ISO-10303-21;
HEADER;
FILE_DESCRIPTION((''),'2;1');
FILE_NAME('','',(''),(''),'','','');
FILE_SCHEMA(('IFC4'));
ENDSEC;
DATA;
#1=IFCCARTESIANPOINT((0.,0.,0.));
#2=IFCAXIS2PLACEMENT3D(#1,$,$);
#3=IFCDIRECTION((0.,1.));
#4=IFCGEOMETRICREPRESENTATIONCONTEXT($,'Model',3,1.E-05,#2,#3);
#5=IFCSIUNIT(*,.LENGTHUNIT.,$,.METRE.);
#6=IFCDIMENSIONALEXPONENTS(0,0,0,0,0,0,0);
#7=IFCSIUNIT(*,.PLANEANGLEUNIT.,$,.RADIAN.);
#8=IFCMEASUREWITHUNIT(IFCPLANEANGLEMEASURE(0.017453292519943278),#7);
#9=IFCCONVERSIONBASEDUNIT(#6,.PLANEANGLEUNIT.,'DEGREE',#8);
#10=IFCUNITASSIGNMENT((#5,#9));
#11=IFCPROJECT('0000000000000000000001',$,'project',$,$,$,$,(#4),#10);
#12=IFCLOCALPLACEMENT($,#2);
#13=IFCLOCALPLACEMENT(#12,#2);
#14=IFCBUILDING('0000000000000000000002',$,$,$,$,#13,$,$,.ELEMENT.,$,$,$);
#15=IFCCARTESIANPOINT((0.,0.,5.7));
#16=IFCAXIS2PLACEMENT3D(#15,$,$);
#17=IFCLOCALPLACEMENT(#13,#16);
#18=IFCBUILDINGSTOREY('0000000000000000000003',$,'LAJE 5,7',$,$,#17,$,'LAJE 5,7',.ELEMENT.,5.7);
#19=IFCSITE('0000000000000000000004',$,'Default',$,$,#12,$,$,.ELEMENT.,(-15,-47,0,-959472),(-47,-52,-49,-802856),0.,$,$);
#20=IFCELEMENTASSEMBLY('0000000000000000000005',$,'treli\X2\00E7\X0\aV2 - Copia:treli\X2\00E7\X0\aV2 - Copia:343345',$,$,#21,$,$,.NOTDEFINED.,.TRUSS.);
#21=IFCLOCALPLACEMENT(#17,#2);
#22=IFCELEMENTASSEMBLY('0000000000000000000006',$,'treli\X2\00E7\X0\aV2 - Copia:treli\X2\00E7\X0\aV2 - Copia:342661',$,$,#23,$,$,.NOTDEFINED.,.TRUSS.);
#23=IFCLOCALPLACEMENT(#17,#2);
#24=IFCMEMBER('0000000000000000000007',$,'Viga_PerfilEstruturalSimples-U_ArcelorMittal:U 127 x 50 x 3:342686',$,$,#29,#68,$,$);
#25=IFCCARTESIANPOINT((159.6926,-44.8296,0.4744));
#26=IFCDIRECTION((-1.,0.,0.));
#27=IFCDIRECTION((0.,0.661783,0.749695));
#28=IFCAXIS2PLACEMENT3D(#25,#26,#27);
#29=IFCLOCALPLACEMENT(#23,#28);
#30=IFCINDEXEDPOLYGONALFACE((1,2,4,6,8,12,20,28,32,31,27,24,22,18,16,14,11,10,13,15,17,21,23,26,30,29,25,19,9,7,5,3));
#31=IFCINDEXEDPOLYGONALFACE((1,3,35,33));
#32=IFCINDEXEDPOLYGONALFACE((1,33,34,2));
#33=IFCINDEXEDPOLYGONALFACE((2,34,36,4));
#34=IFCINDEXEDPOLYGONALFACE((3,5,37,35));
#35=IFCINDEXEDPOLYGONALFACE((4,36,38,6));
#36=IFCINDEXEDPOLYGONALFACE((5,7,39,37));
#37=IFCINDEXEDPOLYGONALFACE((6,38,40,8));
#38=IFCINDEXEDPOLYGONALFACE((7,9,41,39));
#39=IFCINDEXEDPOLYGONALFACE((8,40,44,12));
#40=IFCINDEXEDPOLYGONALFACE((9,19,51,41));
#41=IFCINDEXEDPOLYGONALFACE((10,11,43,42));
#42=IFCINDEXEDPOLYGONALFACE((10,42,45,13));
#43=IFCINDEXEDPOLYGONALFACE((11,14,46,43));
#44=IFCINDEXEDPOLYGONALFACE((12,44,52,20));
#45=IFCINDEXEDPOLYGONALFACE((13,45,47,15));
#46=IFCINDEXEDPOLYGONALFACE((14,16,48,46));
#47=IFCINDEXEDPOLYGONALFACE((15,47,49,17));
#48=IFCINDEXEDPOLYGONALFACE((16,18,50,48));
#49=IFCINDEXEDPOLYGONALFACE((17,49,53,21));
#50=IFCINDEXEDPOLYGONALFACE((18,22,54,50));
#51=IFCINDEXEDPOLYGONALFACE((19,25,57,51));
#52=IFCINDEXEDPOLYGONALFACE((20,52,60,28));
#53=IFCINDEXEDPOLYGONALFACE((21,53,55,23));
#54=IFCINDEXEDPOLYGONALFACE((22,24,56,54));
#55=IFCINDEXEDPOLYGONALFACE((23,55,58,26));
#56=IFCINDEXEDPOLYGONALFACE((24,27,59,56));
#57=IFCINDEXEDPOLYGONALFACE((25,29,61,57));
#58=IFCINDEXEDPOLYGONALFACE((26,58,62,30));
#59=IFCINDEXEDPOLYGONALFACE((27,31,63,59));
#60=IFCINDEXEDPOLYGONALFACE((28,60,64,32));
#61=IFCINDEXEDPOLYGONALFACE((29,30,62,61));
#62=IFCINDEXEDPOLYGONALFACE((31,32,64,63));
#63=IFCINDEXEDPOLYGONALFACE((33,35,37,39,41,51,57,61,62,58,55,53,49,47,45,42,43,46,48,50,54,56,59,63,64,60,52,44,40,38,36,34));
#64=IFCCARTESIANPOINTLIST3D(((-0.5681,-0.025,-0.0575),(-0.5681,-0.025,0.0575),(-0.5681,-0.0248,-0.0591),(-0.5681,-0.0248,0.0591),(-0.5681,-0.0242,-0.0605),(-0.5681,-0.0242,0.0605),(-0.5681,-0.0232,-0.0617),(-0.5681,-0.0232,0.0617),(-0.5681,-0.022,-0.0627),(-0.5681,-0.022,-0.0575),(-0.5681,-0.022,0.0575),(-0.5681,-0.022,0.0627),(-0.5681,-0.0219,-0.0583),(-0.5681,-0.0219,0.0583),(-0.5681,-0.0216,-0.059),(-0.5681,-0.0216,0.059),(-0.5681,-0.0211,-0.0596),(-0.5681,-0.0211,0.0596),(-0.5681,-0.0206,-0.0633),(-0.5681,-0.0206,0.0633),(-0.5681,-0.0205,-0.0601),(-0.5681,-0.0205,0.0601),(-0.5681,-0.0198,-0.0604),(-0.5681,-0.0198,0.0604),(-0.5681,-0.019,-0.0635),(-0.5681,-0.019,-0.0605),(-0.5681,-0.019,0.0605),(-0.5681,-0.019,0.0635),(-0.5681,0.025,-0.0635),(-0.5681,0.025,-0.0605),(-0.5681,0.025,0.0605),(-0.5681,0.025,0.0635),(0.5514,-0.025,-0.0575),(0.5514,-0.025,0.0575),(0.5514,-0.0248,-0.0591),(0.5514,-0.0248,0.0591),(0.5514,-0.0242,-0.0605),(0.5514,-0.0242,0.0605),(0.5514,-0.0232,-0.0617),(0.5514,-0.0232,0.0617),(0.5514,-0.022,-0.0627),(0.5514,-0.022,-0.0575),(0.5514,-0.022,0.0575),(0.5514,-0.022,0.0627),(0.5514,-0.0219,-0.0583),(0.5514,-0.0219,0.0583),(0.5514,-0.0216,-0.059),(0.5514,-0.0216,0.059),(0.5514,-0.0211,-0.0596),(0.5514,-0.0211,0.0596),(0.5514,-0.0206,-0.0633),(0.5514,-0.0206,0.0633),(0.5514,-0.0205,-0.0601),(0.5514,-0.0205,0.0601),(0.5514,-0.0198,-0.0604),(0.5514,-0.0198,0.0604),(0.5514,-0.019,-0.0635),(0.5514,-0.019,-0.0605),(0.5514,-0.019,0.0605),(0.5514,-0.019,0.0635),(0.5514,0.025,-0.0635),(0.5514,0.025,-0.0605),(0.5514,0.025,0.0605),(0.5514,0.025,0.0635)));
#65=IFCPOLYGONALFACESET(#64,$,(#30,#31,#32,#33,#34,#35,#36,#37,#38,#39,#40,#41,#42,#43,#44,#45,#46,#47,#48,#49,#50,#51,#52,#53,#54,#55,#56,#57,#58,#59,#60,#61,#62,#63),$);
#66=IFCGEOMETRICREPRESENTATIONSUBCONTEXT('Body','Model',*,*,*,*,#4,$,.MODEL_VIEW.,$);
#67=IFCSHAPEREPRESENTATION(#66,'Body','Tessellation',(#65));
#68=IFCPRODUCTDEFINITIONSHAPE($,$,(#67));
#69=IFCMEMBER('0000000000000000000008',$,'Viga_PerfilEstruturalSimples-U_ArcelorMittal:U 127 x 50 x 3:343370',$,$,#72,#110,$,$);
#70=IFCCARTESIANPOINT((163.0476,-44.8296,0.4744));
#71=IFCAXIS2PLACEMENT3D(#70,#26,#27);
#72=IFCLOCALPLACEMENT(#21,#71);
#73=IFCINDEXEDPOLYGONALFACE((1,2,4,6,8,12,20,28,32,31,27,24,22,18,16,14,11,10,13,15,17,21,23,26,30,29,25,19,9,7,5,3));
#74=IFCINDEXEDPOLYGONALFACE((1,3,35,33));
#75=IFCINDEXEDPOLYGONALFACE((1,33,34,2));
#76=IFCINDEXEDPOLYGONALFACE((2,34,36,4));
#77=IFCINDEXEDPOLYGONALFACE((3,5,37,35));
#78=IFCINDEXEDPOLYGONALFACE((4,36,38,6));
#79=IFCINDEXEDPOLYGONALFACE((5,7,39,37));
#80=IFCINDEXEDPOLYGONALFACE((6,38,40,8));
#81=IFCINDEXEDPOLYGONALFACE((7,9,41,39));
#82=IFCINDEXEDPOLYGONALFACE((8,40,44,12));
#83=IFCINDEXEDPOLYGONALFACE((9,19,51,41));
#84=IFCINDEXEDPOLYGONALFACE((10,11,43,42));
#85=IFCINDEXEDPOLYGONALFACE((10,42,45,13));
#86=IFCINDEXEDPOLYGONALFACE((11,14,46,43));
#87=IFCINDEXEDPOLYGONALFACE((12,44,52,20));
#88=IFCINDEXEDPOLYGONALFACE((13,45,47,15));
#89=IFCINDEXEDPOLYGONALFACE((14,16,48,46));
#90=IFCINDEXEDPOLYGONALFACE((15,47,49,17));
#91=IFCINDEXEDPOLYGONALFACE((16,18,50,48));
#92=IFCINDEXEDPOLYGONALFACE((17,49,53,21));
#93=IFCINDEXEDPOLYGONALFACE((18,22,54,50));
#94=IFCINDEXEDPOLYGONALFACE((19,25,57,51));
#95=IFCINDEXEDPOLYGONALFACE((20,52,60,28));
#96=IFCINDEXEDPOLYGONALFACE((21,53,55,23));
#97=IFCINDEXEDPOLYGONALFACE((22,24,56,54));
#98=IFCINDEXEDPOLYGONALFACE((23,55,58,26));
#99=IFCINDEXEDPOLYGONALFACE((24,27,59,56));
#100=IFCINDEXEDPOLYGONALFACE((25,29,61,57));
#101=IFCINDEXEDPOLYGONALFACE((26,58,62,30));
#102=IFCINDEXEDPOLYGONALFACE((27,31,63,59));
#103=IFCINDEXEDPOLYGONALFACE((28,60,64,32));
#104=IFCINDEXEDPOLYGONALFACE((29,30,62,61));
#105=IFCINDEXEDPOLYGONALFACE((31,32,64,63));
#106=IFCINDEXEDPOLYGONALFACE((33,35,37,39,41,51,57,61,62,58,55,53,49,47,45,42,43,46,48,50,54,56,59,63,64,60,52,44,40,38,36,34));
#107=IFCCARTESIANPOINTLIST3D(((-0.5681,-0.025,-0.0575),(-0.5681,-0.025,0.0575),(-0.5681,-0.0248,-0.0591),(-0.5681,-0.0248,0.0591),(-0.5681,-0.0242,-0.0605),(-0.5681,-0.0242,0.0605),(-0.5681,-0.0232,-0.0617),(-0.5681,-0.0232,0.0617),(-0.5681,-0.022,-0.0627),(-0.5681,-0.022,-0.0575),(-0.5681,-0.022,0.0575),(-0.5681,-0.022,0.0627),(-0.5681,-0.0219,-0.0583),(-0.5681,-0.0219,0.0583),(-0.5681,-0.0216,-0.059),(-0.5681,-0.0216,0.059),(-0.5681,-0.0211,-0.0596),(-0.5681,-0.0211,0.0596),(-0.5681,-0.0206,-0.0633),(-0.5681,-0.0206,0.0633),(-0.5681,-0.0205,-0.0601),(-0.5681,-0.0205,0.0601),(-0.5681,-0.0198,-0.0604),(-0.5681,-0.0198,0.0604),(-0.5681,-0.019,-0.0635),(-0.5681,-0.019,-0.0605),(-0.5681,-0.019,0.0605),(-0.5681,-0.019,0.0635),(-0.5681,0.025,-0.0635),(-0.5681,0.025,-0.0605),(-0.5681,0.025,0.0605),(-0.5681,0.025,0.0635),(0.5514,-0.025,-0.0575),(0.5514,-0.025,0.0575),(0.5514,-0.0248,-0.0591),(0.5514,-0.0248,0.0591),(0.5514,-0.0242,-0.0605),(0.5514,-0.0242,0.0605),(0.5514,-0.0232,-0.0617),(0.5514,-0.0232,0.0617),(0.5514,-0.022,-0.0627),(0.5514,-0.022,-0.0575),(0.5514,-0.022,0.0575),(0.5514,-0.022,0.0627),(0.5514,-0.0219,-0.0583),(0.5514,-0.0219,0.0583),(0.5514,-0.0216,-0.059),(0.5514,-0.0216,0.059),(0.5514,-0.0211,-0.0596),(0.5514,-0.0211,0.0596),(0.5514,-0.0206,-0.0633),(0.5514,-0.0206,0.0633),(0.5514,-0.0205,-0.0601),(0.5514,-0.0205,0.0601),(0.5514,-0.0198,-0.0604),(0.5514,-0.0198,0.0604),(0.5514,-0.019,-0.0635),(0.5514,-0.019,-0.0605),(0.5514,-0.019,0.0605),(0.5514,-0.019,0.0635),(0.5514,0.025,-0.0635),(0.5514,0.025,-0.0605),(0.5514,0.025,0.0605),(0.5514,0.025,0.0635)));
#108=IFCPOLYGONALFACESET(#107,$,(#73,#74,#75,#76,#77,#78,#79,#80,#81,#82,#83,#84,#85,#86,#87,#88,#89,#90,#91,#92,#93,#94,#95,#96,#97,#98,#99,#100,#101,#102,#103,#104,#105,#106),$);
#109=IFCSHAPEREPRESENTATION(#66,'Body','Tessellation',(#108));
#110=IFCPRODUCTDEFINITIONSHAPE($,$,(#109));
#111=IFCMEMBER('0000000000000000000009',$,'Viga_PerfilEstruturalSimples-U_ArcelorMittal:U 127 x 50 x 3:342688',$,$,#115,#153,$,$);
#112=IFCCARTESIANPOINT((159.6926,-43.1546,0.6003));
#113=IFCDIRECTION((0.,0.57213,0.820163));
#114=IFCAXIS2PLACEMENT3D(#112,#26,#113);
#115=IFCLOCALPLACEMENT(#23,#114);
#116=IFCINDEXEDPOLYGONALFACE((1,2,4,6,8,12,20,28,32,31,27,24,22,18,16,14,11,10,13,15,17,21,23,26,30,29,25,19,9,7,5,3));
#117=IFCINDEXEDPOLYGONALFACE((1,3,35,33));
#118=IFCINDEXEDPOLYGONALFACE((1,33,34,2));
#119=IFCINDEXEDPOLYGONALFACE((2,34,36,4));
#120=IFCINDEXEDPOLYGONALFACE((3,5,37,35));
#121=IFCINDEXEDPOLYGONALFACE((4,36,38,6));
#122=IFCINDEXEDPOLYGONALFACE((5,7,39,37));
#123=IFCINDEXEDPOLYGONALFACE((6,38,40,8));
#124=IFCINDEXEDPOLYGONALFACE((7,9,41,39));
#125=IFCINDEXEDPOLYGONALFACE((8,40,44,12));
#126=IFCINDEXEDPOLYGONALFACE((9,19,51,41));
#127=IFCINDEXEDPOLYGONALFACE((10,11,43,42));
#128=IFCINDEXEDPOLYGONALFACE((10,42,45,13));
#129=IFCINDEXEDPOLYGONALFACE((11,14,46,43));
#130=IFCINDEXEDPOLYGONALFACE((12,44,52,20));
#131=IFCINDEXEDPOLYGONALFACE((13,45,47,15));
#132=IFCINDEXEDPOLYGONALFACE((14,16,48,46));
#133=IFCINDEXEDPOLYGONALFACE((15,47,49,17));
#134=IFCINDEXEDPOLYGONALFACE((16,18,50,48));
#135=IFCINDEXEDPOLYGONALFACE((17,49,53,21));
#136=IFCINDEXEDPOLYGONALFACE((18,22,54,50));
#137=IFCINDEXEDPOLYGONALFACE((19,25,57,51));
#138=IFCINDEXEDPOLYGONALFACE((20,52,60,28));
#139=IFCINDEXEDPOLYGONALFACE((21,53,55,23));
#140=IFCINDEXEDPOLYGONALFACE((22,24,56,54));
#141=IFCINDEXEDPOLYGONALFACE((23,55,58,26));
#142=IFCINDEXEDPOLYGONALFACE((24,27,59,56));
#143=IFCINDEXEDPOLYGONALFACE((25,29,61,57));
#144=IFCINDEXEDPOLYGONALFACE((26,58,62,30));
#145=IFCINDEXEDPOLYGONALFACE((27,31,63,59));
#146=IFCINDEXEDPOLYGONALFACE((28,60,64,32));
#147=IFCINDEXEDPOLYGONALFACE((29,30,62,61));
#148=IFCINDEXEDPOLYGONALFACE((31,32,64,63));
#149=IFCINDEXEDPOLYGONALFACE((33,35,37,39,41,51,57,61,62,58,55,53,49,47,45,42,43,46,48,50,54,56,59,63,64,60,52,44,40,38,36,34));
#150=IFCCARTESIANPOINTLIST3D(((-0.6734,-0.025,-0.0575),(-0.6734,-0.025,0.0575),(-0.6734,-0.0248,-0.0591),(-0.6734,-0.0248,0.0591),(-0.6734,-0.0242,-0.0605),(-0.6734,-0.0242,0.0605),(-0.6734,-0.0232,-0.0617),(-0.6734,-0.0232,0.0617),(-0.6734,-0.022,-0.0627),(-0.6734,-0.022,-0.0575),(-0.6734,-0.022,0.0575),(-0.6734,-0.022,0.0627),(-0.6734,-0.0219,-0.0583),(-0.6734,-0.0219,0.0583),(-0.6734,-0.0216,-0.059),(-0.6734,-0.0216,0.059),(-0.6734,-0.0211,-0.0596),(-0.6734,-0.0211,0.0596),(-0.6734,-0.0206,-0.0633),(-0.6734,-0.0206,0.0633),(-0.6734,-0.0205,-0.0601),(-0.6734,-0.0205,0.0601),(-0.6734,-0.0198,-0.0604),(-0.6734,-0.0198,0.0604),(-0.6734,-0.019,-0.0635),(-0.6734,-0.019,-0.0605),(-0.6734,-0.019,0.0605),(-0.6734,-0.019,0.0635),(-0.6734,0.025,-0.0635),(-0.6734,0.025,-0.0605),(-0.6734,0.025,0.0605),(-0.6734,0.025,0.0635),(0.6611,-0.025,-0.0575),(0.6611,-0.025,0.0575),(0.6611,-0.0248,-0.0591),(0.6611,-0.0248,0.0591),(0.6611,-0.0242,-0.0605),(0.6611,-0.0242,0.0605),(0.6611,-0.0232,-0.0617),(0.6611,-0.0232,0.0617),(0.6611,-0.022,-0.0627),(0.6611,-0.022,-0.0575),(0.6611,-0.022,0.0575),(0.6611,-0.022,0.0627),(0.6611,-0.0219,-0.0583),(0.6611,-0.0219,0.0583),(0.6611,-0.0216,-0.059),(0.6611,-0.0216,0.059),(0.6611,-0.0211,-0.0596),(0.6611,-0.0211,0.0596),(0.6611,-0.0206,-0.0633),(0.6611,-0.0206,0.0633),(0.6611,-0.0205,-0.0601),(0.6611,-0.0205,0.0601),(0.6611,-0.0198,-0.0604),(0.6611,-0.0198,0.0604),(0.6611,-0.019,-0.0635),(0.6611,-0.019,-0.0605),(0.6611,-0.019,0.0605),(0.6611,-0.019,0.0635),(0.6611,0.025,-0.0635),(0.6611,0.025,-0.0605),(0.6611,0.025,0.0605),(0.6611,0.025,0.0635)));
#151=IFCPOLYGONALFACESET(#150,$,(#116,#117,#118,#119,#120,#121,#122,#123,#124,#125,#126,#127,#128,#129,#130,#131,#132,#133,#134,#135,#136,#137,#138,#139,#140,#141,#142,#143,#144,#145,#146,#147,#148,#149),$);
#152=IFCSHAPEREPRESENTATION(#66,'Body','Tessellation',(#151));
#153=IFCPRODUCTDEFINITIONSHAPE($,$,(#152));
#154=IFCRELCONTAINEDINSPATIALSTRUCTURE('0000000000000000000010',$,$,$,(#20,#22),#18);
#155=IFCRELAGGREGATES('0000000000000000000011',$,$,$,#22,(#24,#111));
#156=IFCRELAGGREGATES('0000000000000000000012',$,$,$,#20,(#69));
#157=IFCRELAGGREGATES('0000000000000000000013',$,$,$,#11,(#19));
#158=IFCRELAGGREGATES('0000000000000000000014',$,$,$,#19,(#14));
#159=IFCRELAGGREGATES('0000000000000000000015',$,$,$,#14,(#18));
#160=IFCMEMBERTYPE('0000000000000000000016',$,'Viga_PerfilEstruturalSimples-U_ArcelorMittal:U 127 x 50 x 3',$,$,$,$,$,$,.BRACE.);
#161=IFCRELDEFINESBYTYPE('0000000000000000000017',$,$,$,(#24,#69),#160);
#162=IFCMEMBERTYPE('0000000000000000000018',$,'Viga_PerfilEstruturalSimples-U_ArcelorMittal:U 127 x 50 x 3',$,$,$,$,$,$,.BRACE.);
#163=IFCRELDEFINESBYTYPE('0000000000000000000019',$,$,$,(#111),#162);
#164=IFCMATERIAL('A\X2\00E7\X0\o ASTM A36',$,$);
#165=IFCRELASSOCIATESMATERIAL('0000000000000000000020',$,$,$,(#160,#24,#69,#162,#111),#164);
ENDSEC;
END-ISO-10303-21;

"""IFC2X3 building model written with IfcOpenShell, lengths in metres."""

from ifc_helpers import new_model, entity, si_unit, converted_unit, direction, frame, frame_2d, origin, place, context, subcontext, project, spatial, polyline, circle_curve, parameter, trimmed, segment, composite_curve, outline, extrude, source, transform, mapped, material, type_object, type_shapes, element, aggregate, save


model = new_model("IFC2X3")

# Units and contexts
model_context = context("Model", 3, precision=1e-05, world=origin(), true_north=direction((0.0, 1.0)))
body_context = subcontext(model_context, "Body", "Model", "MODEL_VIEW")
ifc_project = project(units=[si_unit("LENGTHUNIT", "METRE"), converted_unit("PLANEANGLEUNIT", "DEGREE", entity("IfcPlaneAngleMeasure", 0.017453292519943278), si_unit("PLANEANGLEUNIT", "RADIAN"), dimensions=[0, 0, 0, 0, 0, 0, 0])], contexts=[model_context])

# Site, building, storey
site_placement = place(None, origin())
site = spatial("IfcSite", under=ifc_project, at=site_placement, Name="Default", CompositionType="ELEMENT", RefLatitude=(-15, -47, 0, -959472), RefLongitude=(-47, -52, -49, -802856), RefElevation=0.0)
building_placement = place(site_placement, origin())
building = spatial("IfcBuilding", under=site, at=building_placement, CompositionType="ELEMENT")
storey_placement = place(building_placement, frame((0.0, 0.0, 5.7)))
storey = spatial("IfcBuildingStorey", under=building, at=storey_placement, Name="LAJE 5,7", LongName="LAJE 5,7", CompositionType="ELEMENT", Elevation=5.7)

# Element assembly
assembly_1_placement = place(storey_placement, origin())
assembly_1 = element("IfcElementAssembly", 1, at=assembly_1_placement, inside=storey, Name="treliçaV2 - Copia:treliçaV2 - Copia:343345", AssemblyPlace="NOTDEFINED", PredefinedType="TRUSS")
ifc_material = material(Name="Aço ASTM A36")

# Element assembly
assembly_2_placement = place(storey_placement, origin())
assembly_2 = element("IfcElementAssembly", 2, at=assembly_2_placement, inside=storey, Name="treliçaV2 - Copia:treliçaV2 - Copia:342661", AssemblyPlace="NOTDEFINED", PredefinedType="TRUSS")

# Members
member_type_1 = type_object("IfcMemberType", Name="Viga_PerfilEstruturalSimples-U_ArcelorMittal:U 127 x 50 x 3", PredefinedType="BRACE", material=ifc_material)
shared_shape_1 = source(origin(), body_context, "Body", "SweptSolid", [
    extrude(outline(composite_curve([segment(polyline([(-0.0575, -0.0192), (0.0575, -0.0192)]), True, "CONTINUOUS"), segment(trimmed(circle_curve(frame_2d((0.0575, -0.0132), x_axis=(0.0, 1.0)), 0.006), [parameter(180.0)], [parameter(270.0)], True, "PARAMETER"), True, "CONTINUOUS"), segment(polyline([(0.0635, -0.0132), (0.0635, 0.0308)]), True, "CONTINUOUS"), segment(polyline([(0.0635, 0.0308), (0.0605, 0.0308)]), True, "CONTINUOUS"), segment(polyline([(0.0605, 0.0308), (0.0605, -0.0132)]), True, "CONTINUOUS"), segment(trimmed(circle_curve(frame_2d((0.0575, -0.0132), x_axis=(0.0, 1.0)), 0.003), [parameter(180.0)], [parameter(270.0)], True, "PARAMETER"), False, "CONTINUOUS"), segment(polyline([(0.0575, -0.0162), (-0.0575, -0.0162)]), True, "CONTINUOUS"), segment(trimmed(circle_curve(frame_2d((-0.0575, -0.0132), x_axis=(0.0, 1.0)), 0.003), [parameter(90.0)], [parameter(180.0)], True, "PARAMETER"), False, "CONTINUOUS"), segment(polyline([(-0.0605, -0.0132), (-0.0605, 0.0308)]), True, "CONTINUOUS"), segment(polyline([(-0.0605, 0.0308), (-0.0635, 0.0308)]), True, "CONTINUOUS"), segment(polyline([(-0.0635, 0.0308), (-0.0635, -0.0132)]), True, "CONTINUOUS"), segment(trimmed(circle_curve(frame_2d((-0.0575, -0.0132), x_axis=(0.0, 1.0)), 0.006), [parameter(90.0)], [parameter(180.0)], True, "PARAMETER"), True, "CONTINUOUS")], self_intersect=False)), frame((-0.5681, -0.0058, 0.0), z_axis=(1.0, 0.0, 0.0), x_axis=(0.0, 0.0, -1.0)), (0.0, 0.0, 1.0), 1.1195),
])
type_shapes(member_type_1, [shared_shape_1])
member_1_placement = place(assembly_2_placement, frame((159.6926, -44.8296, 0.4744), z_axis=(-1.0, 0.0, 0.0), x_axis=(0.0, 0.661783, 0.749695)))
member_1 = element("IfcMember", 3, at=member_1_placement, type_object=member_type_1, material=ifc_material, Name="Viga_PerfilEstruturalSimples-U_ArcelorMittal:U 127 x 50 x 3:342686", context=body_context, shape_type="MappedRepresentation", body=[
    mapped(shared_shape_1, transform((0.0, 0.0, 0.0), scale=1.0)),
])
member_2_placement = place(assembly_1_placement, frame((163.0476, -44.8296, 0.4744), z_axis=(-1.0, 0.0, 0.0), x_axis=(0.0, 0.661783, 0.749695)))
member_2 = element("IfcMember", 4, at=member_2_placement, type_object=member_type_1, material=ifc_material, Name="Viga_PerfilEstruturalSimples-U_ArcelorMittal:U 127 x 50 x 3:343370", context=body_context, shape_type="MappedRepresentation", body=[
    mapped(shared_shape_1, transform((0.0, 0.0, 0.0), scale=1.0)),
])
member_type_2 = type_object("IfcMemberType", Name="Viga_PerfilEstruturalSimples-U_ArcelorMittal:U 127 x 50 x 3", PredefinedType="BRACE", material=ifc_material)
shared_shape_2 = source(origin(), body_context, "Body", "SweptSolid", [
    extrude(outline(composite_curve([segment(polyline([(-0.0575, -0.0192), (0.0575, -0.0192)]), True, "CONTINUOUS"), segment(trimmed(circle_curve(frame_2d((0.0575, -0.0132), x_axis=(0.0, 1.0)), 0.006), [parameter(180.0)], [parameter(270.0)], True, "PARAMETER"), True, "CONTINUOUS"), segment(polyline([(0.0635, -0.0132), (0.0635, 0.0308)]), True, "CONTINUOUS"), segment(polyline([(0.0635, 0.0308), (0.0605, 0.0308)]), True, "CONTINUOUS"), segment(polyline([(0.0605, 0.0308), (0.0605, -0.0132)]), True, "CONTINUOUS"), segment(trimmed(circle_curve(frame_2d((0.0575, -0.0132), x_axis=(0.0, 1.0)), 0.003), [parameter(180.0)], [parameter(270.0)], True, "PARAMETER"), False, "CONTINUOUS"), segment(polyline([(0.0575, -0.0162), (-0.0575, -0.0162)]), True, "CONTINUOUS"), segment(trimmed(circle_curve(frame_2d((-0.0575, -0.0132), x_axis=(0.0, 1.0)), 0.003), [parameter(90.0)], [parameter(180.0)], True, "PARAMETER"), False, "CONTINUOUS"), segment(polyline([(-0.0605, -0.0132), (-0.0605, 0.0308)]), True, "CONTINUOUS"), segment(polyline([(-0.0605, 0.0308), (-0.0635, 0.0308)]), True, "CONTINUOUS"), segment(polyline([(-0.0635, 0.0308), (-0.0635, -0.0132)]), True, "CONTINUOUS"), segment(trimmed(circle_curve(frame_2d((-0.0575, -0.0132), x_axis=(0.0, 1.0)), 0.006), [parameter(90.0)], [parameter(180.0)], True, "PARAMETER"), True, "CONTINUOUS")], self_intersect=False)), frame((-0.6734, -0.0058, 0.0), z_axis=(1.0, 0.0, 0.0), x_axis=(0.0, 0.0, -1.0)), (0.0, 0.0, 1.0), 1.3345),
])
type_shapes(member_type_2, [shared_shape_2])
member_3_placement = place(assembly_2_placement, frame((159.6926, -43.1546, 0.6003), z_axis=(-1.0, 0.0, 0.0), x_axis=(0.0, 0.57213, 0.820163)))
member_3 = element("IfcMember", 5, at=member_3_placement, type_object=member_type_2, material=ifc_material, Name="Viga_PerfilEstruturalSimples-U_ArcelorMittal:U 127 x 50 x 3:342688", context=body_context, shape_type="MappedRepresentation", body=[
    mapped(shared_shape_2, transform((0.0, 0.0, 0.0), scale=1.0)),
])
aggregate(assembly_2, [member_1, member_3])
aggregate(assembly_1, [member_2])

save(model, "model.ifc")
